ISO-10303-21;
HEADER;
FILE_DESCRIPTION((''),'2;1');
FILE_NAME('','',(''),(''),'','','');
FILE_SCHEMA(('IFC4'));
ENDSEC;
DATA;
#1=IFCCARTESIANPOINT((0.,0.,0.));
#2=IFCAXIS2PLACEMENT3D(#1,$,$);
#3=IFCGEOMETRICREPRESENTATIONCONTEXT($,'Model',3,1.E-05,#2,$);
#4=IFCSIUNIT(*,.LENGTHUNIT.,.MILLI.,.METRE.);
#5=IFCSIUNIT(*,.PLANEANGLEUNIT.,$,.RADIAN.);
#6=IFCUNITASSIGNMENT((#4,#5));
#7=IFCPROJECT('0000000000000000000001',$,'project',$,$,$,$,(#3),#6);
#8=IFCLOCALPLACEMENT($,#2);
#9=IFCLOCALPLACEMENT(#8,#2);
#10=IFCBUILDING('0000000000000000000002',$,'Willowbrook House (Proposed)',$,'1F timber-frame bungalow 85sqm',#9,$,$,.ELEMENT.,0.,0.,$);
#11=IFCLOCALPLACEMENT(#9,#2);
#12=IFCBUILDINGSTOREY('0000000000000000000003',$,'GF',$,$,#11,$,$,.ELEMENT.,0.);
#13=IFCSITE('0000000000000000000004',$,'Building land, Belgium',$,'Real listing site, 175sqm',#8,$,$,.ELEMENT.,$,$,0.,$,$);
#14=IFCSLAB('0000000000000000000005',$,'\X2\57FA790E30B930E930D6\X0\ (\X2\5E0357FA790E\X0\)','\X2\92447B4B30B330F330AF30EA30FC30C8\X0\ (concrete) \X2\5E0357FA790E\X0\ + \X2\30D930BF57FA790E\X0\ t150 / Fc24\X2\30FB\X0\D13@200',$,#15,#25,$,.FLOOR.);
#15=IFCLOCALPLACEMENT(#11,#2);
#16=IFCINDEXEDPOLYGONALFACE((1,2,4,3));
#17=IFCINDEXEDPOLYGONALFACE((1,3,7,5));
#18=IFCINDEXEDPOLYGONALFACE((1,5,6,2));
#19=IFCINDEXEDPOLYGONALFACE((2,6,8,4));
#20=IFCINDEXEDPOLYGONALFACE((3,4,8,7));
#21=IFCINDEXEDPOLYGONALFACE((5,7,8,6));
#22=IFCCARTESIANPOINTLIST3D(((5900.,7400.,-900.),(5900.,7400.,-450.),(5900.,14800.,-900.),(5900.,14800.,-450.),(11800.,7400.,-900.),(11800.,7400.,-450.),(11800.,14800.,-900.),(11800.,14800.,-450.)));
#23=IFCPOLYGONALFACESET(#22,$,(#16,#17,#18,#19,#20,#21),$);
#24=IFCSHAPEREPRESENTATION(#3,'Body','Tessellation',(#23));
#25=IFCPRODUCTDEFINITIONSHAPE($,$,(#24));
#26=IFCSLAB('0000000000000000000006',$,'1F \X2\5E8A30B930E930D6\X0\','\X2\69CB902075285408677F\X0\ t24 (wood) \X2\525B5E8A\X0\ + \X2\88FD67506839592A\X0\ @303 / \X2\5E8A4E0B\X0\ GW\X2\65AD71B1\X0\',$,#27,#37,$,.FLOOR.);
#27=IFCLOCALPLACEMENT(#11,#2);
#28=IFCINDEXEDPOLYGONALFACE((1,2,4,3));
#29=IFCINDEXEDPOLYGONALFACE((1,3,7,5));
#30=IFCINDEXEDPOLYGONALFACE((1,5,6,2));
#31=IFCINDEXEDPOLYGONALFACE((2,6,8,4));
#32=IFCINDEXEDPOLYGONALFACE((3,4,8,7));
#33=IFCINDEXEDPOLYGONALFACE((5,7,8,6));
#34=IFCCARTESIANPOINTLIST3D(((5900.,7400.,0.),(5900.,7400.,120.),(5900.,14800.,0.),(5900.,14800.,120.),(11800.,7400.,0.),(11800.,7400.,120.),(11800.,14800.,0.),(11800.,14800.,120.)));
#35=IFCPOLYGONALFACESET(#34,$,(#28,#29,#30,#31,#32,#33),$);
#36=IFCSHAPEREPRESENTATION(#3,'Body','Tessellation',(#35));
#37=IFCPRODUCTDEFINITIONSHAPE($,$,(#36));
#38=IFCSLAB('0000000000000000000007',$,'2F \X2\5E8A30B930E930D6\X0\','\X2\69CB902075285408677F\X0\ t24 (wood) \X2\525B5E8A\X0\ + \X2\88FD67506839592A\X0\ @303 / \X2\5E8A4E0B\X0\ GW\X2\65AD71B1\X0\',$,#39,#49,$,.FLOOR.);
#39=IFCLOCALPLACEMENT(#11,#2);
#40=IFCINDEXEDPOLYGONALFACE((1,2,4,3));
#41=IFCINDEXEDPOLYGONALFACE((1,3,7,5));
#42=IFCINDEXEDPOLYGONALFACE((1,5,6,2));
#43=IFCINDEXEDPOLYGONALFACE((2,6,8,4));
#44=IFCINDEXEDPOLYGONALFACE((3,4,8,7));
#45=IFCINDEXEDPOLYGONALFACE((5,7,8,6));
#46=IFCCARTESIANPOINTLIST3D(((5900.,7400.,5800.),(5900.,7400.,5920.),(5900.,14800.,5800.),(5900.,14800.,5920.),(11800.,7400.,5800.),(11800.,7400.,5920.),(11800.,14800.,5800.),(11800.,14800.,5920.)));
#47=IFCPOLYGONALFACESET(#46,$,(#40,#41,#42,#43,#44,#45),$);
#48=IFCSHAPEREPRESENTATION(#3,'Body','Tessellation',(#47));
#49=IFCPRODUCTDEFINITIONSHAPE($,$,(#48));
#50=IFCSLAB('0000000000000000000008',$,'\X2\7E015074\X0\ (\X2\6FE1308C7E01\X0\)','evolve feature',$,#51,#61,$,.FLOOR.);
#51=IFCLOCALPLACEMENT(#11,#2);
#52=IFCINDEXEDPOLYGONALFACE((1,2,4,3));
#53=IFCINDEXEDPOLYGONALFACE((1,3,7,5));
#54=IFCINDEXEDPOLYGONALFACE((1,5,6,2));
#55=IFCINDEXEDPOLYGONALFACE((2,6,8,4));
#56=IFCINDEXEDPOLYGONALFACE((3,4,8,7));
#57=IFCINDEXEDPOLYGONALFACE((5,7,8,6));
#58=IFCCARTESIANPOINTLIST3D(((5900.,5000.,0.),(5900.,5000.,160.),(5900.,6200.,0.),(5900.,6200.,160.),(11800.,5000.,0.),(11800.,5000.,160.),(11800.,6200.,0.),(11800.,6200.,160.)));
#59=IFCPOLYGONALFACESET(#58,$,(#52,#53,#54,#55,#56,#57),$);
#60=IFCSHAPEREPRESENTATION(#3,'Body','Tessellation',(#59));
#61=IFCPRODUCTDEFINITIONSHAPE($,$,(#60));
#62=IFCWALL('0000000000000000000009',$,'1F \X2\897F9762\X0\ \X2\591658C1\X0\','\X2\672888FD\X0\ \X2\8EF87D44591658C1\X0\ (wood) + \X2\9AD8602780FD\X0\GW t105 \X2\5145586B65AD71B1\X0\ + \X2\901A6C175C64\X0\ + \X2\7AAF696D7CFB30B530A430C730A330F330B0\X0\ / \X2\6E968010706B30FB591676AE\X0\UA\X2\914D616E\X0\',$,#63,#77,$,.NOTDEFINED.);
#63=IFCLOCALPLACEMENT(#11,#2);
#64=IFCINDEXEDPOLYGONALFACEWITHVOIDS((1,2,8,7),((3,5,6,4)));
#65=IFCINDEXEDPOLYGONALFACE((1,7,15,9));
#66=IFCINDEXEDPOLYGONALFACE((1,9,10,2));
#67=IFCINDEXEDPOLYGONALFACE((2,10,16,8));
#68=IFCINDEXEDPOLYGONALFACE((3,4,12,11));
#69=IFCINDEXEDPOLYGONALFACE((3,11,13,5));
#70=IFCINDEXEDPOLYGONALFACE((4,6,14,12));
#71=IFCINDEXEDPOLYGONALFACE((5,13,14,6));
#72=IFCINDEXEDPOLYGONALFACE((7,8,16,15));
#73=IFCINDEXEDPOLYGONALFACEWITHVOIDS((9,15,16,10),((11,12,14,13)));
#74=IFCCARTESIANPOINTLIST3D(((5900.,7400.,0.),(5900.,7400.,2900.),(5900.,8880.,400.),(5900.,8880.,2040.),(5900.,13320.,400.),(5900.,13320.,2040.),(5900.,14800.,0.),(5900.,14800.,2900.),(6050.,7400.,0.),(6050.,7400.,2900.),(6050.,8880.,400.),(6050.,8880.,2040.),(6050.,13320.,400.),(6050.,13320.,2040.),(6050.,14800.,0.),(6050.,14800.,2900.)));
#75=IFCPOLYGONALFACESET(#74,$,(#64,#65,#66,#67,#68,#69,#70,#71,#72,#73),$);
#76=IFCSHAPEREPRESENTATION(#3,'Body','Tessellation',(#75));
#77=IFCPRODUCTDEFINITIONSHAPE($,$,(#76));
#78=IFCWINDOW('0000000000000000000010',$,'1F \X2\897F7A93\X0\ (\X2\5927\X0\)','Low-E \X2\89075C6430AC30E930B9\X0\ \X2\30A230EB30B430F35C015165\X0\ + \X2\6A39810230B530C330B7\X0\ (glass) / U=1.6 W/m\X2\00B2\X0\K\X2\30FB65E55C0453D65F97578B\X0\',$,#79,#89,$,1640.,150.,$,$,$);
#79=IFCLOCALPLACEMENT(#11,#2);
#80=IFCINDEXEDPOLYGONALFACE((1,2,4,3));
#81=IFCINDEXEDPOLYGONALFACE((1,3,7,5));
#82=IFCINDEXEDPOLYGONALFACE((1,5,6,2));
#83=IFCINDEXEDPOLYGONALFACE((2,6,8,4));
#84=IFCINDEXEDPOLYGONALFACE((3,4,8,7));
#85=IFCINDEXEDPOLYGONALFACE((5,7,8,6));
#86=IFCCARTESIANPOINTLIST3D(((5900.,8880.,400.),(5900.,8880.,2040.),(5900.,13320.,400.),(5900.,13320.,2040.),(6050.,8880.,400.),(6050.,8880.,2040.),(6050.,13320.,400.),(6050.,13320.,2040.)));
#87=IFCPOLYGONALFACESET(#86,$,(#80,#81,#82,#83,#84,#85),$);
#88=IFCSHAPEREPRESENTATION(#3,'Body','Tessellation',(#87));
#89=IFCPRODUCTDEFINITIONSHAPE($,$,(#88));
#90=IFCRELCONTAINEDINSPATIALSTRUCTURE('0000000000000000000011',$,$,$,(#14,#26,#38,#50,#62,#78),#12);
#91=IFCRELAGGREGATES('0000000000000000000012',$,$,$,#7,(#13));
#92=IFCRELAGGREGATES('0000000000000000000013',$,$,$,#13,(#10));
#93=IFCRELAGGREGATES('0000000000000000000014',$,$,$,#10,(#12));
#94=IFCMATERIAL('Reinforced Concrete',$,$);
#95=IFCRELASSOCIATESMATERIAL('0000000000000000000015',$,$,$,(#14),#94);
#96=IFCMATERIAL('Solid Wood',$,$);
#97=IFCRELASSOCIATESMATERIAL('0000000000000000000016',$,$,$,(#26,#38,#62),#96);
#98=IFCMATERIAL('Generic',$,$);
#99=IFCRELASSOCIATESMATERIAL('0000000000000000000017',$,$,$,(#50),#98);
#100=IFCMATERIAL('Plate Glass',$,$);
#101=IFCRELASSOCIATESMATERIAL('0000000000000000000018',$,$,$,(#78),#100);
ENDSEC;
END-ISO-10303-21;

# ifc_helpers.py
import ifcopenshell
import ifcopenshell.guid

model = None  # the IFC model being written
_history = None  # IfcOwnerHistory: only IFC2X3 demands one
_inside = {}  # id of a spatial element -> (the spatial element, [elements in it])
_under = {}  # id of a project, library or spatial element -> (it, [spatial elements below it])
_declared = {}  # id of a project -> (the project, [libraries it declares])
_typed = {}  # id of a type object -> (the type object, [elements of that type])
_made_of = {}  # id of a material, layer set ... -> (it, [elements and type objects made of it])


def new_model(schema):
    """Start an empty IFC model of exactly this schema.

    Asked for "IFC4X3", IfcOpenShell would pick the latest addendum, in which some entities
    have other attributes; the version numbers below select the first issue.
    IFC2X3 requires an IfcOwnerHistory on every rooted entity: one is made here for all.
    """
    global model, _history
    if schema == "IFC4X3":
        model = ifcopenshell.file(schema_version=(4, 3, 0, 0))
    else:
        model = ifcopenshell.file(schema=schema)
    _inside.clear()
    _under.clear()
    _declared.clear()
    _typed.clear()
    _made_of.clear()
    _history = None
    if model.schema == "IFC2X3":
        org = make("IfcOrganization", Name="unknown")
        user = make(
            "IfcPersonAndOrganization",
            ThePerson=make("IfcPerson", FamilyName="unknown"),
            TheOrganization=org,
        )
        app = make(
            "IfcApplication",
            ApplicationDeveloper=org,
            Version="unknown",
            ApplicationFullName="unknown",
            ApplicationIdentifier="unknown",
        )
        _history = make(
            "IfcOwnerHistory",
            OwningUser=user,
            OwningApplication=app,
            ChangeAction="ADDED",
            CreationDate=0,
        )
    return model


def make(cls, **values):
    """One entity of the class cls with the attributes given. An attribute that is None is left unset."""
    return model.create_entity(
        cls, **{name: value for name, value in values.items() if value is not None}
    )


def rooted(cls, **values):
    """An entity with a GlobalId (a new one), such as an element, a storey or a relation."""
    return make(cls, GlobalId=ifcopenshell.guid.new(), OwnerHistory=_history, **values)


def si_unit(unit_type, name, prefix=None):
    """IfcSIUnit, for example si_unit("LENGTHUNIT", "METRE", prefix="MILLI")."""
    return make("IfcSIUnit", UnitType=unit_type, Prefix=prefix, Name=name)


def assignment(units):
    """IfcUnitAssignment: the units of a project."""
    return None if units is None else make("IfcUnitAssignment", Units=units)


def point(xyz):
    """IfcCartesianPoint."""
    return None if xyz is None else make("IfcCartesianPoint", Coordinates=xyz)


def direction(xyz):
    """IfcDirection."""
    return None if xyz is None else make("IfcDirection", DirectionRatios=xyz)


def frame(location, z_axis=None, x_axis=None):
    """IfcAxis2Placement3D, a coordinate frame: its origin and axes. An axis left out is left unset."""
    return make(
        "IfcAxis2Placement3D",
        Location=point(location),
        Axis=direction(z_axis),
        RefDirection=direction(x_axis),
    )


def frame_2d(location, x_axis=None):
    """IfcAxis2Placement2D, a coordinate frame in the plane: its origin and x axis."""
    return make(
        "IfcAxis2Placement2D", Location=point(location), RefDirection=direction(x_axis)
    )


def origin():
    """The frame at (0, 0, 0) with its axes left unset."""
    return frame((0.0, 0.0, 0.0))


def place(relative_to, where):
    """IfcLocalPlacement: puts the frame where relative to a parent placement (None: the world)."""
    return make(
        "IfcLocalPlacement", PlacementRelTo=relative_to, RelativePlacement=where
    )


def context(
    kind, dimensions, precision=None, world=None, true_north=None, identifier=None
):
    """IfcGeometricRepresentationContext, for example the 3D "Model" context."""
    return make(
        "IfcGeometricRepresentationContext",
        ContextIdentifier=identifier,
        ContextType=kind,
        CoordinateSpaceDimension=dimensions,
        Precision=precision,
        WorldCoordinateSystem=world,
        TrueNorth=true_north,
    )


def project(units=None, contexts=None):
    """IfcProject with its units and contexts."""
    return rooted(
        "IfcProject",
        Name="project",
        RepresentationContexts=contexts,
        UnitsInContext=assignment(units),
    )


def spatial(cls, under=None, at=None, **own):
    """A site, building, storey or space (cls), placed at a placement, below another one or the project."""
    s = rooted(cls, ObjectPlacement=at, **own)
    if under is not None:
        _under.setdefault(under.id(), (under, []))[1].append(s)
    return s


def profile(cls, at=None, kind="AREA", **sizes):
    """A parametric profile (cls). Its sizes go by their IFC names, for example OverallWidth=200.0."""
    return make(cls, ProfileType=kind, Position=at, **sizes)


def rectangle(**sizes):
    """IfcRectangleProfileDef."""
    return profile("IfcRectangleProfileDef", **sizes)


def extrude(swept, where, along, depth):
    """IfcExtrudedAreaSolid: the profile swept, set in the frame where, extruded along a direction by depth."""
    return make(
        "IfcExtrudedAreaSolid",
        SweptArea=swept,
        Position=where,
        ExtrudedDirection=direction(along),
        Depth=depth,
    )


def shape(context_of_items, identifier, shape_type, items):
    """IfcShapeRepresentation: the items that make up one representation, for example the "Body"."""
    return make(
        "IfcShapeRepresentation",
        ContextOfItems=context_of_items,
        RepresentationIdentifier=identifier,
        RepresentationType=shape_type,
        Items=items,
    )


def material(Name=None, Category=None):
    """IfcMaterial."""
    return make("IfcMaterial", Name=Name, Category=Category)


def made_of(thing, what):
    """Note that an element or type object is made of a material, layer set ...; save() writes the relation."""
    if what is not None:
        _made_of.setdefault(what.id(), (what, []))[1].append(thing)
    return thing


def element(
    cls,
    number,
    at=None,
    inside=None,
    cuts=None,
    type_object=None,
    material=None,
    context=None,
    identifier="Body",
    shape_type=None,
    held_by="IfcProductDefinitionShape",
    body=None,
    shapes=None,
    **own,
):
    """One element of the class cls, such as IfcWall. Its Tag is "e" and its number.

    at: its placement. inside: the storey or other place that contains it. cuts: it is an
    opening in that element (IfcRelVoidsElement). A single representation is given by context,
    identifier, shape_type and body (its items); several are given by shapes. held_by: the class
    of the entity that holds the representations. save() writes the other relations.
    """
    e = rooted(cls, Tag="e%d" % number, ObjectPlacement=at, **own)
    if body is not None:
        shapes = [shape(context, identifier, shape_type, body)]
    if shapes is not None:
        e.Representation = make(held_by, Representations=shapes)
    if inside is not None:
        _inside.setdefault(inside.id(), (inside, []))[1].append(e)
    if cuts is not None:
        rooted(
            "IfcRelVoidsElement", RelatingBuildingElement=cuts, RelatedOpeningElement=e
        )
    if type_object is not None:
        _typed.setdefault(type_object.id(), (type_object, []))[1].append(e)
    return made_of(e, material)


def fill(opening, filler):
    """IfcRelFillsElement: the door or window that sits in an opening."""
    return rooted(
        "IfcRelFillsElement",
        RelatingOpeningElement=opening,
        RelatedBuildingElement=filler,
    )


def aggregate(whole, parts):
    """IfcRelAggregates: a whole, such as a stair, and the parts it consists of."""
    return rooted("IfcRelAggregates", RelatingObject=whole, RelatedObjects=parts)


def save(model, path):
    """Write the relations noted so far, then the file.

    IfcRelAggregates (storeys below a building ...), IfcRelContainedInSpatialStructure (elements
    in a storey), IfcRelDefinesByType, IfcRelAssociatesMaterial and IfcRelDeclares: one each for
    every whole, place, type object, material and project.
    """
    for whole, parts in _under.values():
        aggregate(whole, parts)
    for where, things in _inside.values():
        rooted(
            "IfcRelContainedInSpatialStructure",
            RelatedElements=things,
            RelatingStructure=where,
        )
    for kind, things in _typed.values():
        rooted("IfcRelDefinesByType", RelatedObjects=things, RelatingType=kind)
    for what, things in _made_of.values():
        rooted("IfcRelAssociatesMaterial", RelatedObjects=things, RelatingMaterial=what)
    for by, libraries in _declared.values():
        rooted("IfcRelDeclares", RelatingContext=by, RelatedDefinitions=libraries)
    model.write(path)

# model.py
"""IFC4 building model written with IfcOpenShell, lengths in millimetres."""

from ifc_helpers import new_model, si_unit, frame, frame_2d, origin, place, context, project, spatial, rectangle, extrude, material, element, fill, save


model = new_model("IFC4")

# Units and contexts
model_context = context("Model", 3, precision=1e-05, world=origin())
ifc_project = project(units=[si_unit("LENGTHUNIT", "METRE", prefix="MILLI"), si_unit("PLANEANGLEUNIT", "RADIAN")], contexts=[model_context])

# Site, building, storey
site_placement = place(None, origin())
site = spatial("IfcSite", under=ifc_project, at=site_placement, Name="Building land, Belgium", ObjectType="Real listing site, 175sqm", CompositionType="ELEMENT", RefElevation=0.0)
building_placement = place(site_placement, origin())
building = spatial("IfcBuilding", under=site, at=building_placement, Name="Willowbrook House (Proposed)", ObjectType="1F timber-frame bungalow 85sqm", CompositionType="ELEMENT", ElevationOfRefHeight=0.0, ElevationOfTerrain=0.0)
storey_placement = place(building_placement, origin())
storey = spatial("IfcBuildingStorey", under=building, at=storey_placement, Name="GF", CompositionType="ELEMENT", Elevation=0.0)

# Slabs
ifc_material_1 = material(Name="Reinforced Concrete")
slab_1_placement = place(storey_placement, frame((2950.0, 3700.0, -450.0)))
element("IfcSlab", 1, at=slab_1_placement, inside=storey, material=ifc_material_1, Name="基礎スラブ (布基礎)", Description="鉄筋コンクリート (concrete) 布基礎 + ベタ基礎 t150 / Fc24・D13@200", PredefinedType="FLOOR", context=model_context, shape_type="SweptSolid", body=[
    extrude(rectangle(XDim=5900.0, YDim=7400.0, at=frame_2d((2950.0, 3700.0))), frame((2950.0, 3700.0, -450.0)), (0.0, 0.0, 1.0), 450.0),
])
ifc_material_2 = material(Name="Solid Wood")
slab_2_placement = place(storey_placement, frame((2950.0, 3700.0, 0.0)))
element("IfcSlab", 2, at=slab_2_placement, inside=storey, material=ifc_material_2, Name="1F 床スラブ", Description="構造用合板 t24 (wood) 剛床 + 製材根太 @303 / 床下 GW断熱", PredefinedType="FLOOR", context=model_context, shape_type="SweptSolid", body=[
    extrude(rectangle(XDim=5900.0, YDim=7400.0, at=frame_2d((2950.0, 3700.0))), frame((2950.0, 3700.0, 0.0)), (0.0, 0.0, 1.0), 120.0),
])
slab_3_placement = place(storey_placement, frame((2950.0, 3700.0, 2900.0)))
element("IfcSlab", 3, at=slab_3_placement, inside=storey, material=ifc_material_2, Name="2F 床スラブ", Description="構造用合板 t24 (wood) 剛床 + 製材根太 @303 / 床下 GW断熱", PredefinedType="FLOOR", context=model_context, shape_type="SweptSolid", body=[
    extrude(rectangle(XDim=5900.0, YDim=7400.0, at=frame_2d((2950.0, 3700.0))), frame((2950.0, 3700.0, 2900.0)), (0.0, 0.0, 1.0), 120.0),
])
ifc_material_3 = material(Name="Generic")
slab_4_placement = place(storey_placement, frame((2950.0, 2500.0, 0.0)))
element("IfcSlab", 4, at=slab_4_placement, inside=storey, material=ifc_material_3, Name="縁側 (濡れ縁)", Description="evolve feature", PredefinedType="FLOOR", context=model_context, shape_type="SweptSolid", body=[
    extrude(rectangle(XDim=5900.0, YDim=1200.0, at=frame_2d((2950.0, 600.0))), frame((2950.0, 2500.0, 0.0)), (0.0, 0.0, 1.0), 160.0),
])

# Shared definitions
ifc_material_4 = material(Name="Plate Glass")

# Wall, opening, window
wall_1_placement = place(storey_placement, frame((2950.0, 3700.0, 0.0)))
wall_1 = element("IfcWall", 5, at=wall_1_placement, inside=storey, material=ifc_material_2, Name="1F 西面 外壁", Description="木製 軸組外壁 (wood) + 高性能GW t105 充填断熱 + 通気層 + 窯業系サイディング / 準耐火・外皮UA配慮", PredefinedType="NOTDEFINED", context=model_context, shape_type="SweptSolid", body=[
    extrude(rectangle(XDim=150.0, YDim=7400.0, at=frame_2d((75.0, 3700.0))), frame((2950.0, 3700.0, 0.0)), (0.0, 0.0, 1.0), 2900.0),
])
opening_1_placement = place(storey_placement, frame((2950.0, 4440.0, 200.0)))
opening_1 = element("IfcOpeningElement", 6, at=opening_1_placement, cuts=wall_1, PredefinedType="NOTDEFINED", context=model_context, shape_type="SweptSolid", body=[
    extrude(rectangle(XDim=150.0, YDim=4440.0, at=frame_2d((75.0, 2220.0))), frame((2950.0, 4440.0, 200.0)), (0.0, 0.0, 1.0), 1640.0),
])
window_1_placement = place(storey_placement, frame((2950.0, 4440.0, 200.0)))
window_1 = element("IfcWindow", 7, at=window_1_placement, inside=storey, material=ifc_material_4, Name="1F 西窓 (大)", Description="Low-E 複層ガラス アルゴン封入 + 樹脂サッシ (glass) / U=1.6 W/m²K・日射取得型", OverallHeight=1640.0, OverallWidth=150.0, context=model_context, shape_type="SweptSolid", body=[
    extrude(rectangle(XDim=150.0, YDim=4440.0, at=frame_2d((75.0, 2220.0))), frame((2950.0, 4440.0, 200.0)), (0.0, 0.0, 1.0), 1640.0),
])
fill(opening_1, window_1)

save(model, "model.ifc")
